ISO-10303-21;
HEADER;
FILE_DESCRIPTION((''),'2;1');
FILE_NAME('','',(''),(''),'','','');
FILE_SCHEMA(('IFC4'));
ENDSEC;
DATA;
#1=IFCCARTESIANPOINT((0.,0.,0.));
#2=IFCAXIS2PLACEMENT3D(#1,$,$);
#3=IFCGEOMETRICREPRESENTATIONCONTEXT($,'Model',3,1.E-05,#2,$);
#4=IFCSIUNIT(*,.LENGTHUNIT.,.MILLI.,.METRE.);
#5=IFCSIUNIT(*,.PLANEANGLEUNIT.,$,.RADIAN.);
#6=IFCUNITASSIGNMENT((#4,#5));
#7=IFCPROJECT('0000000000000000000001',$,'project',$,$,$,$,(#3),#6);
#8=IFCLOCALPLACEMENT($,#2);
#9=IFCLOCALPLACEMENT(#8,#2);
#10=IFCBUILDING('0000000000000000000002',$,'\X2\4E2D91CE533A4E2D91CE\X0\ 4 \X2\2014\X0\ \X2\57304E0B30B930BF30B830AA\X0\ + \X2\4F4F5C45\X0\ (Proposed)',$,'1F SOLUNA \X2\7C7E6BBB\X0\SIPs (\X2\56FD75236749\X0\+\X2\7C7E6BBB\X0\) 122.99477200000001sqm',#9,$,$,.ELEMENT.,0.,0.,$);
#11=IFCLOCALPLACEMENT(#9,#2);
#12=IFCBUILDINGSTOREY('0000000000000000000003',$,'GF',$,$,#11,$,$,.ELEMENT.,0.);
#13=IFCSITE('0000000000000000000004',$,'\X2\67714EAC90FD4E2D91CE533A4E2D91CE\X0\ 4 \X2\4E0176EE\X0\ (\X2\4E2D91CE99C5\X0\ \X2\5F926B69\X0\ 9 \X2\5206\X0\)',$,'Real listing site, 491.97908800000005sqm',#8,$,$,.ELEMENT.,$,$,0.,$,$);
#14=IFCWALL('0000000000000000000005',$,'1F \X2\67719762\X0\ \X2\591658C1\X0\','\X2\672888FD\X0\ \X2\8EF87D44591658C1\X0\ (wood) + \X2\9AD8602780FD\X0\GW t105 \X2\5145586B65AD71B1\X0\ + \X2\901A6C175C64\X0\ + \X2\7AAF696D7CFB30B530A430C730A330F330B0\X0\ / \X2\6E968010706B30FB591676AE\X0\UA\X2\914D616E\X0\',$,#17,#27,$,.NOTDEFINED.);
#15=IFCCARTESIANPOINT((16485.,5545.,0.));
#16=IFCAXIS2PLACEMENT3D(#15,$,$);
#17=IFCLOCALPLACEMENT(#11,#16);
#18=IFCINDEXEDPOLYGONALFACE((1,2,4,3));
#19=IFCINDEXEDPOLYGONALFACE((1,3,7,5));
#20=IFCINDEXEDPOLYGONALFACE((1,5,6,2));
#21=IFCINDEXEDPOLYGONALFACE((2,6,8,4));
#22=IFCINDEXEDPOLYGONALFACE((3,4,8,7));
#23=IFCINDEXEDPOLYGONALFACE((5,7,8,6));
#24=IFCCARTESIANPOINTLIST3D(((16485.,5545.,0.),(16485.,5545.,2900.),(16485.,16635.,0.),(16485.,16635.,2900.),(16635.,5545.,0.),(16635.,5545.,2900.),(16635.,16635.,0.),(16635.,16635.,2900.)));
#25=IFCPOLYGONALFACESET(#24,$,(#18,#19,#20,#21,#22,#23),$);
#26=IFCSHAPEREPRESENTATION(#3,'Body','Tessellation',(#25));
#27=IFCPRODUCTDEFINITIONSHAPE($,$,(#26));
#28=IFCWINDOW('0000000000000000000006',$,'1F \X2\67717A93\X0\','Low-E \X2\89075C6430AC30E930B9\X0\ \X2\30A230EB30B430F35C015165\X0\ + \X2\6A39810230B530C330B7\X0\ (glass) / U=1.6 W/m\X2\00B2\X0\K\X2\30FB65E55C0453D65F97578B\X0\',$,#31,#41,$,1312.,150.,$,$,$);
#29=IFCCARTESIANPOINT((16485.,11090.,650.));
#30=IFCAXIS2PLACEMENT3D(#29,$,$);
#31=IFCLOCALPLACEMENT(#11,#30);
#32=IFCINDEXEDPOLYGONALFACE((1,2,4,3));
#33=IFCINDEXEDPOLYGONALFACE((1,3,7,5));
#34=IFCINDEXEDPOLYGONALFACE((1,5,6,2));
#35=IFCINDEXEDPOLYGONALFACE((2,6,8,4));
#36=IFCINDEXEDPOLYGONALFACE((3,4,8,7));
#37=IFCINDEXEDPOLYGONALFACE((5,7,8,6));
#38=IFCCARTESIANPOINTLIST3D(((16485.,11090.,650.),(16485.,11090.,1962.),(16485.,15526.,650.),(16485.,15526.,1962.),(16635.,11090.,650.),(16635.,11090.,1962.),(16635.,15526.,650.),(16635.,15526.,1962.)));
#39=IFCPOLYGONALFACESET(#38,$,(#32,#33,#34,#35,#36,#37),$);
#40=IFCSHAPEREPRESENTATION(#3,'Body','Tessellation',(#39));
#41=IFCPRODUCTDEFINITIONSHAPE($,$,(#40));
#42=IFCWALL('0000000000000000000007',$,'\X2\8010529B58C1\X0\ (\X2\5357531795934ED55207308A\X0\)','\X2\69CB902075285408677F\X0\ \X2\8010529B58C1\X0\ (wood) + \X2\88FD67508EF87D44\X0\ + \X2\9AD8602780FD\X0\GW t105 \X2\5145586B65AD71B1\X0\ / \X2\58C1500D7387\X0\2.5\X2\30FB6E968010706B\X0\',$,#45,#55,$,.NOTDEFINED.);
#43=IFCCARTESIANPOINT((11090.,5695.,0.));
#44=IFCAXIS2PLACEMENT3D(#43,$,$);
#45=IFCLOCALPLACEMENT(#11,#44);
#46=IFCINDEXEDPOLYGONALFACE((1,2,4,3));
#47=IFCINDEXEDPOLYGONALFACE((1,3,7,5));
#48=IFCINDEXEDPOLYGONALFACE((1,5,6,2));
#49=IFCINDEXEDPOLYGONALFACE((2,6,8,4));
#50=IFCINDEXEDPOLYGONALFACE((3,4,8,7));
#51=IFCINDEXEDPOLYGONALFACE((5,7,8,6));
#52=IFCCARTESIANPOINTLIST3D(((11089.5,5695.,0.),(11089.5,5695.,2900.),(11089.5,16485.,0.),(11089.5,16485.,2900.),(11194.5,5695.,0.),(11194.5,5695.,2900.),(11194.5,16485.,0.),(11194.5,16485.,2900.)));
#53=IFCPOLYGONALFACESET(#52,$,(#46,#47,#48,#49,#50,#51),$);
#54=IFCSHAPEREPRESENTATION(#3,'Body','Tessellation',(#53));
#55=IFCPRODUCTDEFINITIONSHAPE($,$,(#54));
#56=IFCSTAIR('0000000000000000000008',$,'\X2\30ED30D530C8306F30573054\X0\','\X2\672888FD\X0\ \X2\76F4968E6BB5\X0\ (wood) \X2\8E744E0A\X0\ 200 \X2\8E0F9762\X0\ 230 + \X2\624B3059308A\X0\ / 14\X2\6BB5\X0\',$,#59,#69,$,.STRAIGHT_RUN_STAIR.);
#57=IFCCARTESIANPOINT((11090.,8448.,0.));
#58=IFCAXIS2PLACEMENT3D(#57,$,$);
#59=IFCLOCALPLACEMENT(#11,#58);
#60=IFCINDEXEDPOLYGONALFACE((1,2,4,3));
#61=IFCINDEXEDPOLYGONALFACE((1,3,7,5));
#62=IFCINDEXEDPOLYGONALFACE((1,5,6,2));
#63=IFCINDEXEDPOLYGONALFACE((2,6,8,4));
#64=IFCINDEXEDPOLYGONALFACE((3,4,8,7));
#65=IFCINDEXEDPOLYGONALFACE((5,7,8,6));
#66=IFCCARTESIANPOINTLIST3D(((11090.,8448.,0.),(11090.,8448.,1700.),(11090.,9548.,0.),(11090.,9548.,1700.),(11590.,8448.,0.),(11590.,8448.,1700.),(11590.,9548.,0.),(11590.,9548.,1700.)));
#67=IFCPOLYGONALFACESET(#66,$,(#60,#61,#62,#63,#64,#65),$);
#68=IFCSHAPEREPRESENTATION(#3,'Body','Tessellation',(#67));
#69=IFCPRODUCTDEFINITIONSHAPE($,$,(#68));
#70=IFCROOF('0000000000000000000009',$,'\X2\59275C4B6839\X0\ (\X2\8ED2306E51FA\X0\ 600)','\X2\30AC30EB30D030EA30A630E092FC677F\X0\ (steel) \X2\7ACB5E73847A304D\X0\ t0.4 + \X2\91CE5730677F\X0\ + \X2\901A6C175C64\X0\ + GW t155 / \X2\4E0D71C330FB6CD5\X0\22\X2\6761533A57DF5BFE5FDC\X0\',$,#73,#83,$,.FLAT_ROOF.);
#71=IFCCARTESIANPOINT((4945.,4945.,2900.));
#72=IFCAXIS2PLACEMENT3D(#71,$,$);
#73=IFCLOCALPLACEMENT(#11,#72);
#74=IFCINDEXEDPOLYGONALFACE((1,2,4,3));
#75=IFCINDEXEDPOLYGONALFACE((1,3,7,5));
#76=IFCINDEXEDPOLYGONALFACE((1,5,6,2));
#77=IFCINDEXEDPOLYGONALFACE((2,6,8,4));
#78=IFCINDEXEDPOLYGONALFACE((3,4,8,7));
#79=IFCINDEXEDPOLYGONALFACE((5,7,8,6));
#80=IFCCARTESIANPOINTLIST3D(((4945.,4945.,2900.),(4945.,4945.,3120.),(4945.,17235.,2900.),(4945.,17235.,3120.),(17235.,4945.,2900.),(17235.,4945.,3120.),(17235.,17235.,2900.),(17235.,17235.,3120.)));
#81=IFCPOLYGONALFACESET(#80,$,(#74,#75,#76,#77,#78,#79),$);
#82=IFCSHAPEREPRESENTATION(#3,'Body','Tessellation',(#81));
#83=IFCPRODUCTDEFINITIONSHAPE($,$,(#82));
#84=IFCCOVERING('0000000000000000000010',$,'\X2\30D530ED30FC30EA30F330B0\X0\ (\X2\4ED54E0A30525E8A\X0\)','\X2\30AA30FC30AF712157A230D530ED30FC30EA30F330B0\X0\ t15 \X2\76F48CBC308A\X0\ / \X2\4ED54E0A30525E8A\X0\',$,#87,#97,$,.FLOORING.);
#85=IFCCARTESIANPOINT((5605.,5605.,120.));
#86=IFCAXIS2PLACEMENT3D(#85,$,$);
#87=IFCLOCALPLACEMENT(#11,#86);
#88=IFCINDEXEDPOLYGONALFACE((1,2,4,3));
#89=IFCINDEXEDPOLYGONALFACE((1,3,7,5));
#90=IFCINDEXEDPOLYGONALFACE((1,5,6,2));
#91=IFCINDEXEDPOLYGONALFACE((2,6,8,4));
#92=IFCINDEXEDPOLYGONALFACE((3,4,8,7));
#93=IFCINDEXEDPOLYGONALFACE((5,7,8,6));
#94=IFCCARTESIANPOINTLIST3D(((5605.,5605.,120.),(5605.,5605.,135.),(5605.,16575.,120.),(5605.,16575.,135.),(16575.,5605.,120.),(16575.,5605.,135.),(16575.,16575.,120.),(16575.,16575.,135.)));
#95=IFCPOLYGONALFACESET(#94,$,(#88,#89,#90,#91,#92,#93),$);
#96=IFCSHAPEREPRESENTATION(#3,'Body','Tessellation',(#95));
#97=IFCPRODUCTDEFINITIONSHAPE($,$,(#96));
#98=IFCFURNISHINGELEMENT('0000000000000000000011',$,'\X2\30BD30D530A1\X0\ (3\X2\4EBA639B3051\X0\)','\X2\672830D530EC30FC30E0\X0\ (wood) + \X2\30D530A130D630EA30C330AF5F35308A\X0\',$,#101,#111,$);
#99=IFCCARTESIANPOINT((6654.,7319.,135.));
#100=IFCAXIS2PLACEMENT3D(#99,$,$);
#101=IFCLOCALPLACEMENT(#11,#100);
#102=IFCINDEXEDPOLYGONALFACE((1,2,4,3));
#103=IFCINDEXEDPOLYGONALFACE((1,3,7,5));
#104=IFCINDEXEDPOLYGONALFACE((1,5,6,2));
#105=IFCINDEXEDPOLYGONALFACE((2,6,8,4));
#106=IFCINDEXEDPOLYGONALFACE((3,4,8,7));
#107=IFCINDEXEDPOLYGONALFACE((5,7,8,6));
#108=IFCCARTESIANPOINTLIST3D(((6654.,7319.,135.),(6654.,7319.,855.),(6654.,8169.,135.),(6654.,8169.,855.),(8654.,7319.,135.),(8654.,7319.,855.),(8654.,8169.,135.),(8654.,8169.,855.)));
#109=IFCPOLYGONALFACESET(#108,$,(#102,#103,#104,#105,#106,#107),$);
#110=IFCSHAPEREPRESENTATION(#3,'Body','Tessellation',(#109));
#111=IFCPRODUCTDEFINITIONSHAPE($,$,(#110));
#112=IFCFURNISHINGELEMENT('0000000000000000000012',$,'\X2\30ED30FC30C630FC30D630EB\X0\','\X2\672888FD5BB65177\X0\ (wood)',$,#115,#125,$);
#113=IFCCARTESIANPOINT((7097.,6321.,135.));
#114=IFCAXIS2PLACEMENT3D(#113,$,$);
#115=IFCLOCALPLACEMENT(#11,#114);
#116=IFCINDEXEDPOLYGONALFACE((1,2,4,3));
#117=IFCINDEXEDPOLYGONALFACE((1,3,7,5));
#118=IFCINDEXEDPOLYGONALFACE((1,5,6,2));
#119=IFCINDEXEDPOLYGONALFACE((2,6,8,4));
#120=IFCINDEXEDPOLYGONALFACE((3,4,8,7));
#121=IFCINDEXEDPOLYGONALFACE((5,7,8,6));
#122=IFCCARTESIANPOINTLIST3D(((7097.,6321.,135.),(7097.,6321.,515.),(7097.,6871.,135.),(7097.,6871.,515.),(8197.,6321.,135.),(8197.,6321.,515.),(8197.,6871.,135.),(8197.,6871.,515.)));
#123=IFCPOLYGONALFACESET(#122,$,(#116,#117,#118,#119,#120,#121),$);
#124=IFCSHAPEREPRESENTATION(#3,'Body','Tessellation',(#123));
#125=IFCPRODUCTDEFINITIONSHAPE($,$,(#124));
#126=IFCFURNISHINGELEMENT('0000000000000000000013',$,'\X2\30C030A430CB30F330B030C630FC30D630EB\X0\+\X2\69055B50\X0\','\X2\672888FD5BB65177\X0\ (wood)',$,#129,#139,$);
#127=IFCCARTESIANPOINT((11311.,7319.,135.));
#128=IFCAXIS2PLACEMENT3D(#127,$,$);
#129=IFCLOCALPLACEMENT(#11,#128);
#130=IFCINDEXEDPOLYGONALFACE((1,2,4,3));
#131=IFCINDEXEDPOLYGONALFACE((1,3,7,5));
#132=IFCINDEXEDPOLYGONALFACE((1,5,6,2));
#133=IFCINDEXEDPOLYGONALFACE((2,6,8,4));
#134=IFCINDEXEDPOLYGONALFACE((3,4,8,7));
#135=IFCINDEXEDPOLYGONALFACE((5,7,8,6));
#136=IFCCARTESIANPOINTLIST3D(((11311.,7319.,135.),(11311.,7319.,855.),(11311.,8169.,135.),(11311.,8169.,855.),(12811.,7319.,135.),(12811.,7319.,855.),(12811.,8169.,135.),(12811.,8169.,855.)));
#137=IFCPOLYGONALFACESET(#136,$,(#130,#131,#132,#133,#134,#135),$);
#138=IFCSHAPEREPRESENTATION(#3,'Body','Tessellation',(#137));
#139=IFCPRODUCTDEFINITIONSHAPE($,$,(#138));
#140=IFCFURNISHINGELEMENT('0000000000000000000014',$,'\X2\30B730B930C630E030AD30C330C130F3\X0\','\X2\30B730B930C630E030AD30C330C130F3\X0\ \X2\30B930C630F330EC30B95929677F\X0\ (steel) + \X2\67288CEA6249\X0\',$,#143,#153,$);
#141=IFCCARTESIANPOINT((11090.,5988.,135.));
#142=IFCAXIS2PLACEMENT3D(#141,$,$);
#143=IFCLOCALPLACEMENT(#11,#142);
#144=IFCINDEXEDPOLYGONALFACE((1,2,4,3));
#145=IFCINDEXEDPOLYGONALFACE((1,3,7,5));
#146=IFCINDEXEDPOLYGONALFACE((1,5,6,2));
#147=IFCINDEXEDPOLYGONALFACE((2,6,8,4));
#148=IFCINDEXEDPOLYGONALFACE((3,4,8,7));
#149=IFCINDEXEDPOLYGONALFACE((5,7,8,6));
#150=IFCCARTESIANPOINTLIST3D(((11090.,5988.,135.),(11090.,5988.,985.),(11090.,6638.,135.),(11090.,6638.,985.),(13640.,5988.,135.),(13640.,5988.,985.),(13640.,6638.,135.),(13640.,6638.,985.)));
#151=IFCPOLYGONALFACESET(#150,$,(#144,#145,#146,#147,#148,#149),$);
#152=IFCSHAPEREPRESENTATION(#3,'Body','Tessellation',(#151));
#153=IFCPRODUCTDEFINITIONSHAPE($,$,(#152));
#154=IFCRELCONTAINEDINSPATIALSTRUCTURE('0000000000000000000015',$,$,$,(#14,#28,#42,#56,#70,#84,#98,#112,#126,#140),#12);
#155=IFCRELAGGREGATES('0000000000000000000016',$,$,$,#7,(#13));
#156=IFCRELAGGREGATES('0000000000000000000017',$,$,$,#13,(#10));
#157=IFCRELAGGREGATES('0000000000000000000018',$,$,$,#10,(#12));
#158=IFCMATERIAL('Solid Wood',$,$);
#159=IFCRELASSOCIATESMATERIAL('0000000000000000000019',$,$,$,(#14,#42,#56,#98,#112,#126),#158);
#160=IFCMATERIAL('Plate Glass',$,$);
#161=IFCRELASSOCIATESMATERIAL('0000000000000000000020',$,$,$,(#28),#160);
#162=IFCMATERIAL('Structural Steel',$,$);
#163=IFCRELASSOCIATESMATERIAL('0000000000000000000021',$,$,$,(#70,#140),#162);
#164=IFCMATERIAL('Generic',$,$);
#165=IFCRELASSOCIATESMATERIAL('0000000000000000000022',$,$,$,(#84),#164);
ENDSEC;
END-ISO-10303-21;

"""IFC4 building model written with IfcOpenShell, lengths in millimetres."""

from ifc_helpers import new_model, si_unit, frame, frame_2d, origin, place, context, project, spatial, rectangle, extrude, material, element, fill, save


model = new_model("IFC4")

# Units and contexts
model_context = context("Model", 3, precision=1e-05, world=origin())
ifc_project = project(units=[si_unit("LENGTHUNIT", "METRE", prefix="MILLI"), si_unit("PLANEANGLEUNIT", "RADIAN")], contexts=[model_context])

# Site, building, storey
site_placement = place(None, origin())
site = spatial("IfcSite", under=ifc_project, at=site_placement, Name="東京都中野区中野 4 丁目 (中野駅 徒歩 9 分)", ObjectType="Real listing site, 491.97908800000005sqm", CompositionType="ELEMENT", RefElevation=0.0)
building_placement = place(site_placement, origin())
building = spatial("IfcBuilding", under=site, at=building_placement, Name="中野区中野 4 — 地下スタジオ + 住居 (Proposed)", ObjectType="1F SOLUNA 籾殻SIPs (国産杉+籾殻) 122.99477200000001sqm", CompositionType="ELEMENT", ElevationOfRefHeight=0.0, ElevationOfTerrain=0.0)
storey_placement = place(building_placement, origin())
storey = spatial("IfcBuildingStorey", under=building, at=storey_placement, Name="GF", CompositionType="ELEMENT", Elevation=0.0)

# Shared definitions
ifc_material_1 = material(Name="Solid Wood")

# Shared definitions
ifc_material_2 = material(Name="Plate Glass")

# Wall, opening, window
wall_1_placement = place(storey_placement, frame((16485.0, 5545.0, 0.0)))
wall_1 = element("IfcWall", 1, at=wall_1_placement, inside=storey, material=ifc_material_1, Name="1F 東面 外壁", Description="木製 軸組外壁 (wood) + 高性能GW t105 充填断熱 + 通気層 + 窯業系サイディング / 準耐火・外皮UA配慮", PredefinedType="NOTDEFINED", context=model_context, shape_type="SweptSolid", body=[
    extrude(rectangle(XDim=150.0, YDim=11090.0, at=frame_2d((75.0, 5545.0))), frame((16485.0, 5545.0, 0.0)), (0.0, 0.0, 1.0), 2900.0),
])
opening_1_placement = place(storey_placement, frame((16485.0, 11090.0, 650.0)))
opening_1 = element("IfcOpeningElement", 2, at=opening_1_placement, cuts=wall_1, PredefinedType="NOTDEFINED", context=model_context, shape_type="SweptSolid", body=[
    extrude(rectangle(XDim=150.0, YDim=4436.0, at=frame_2d((75.0, 2218.0))), frame((16485.0, 11090.0, 650.0)), (0.0, 0.0, 1.0), 1312.0),
])
window_1_placement = place(storey_placement, frame((16485.0, 11090.0, 650.0)))
window_1 = element("IfcWindow", 3, at=window_1_placement, inside=storey, material=ifc_material_2, Name="1F 東窓", Description="Low-E 複層ガラス アルゴン封入 + 樹脂サッシ (glass) / U=1.6 W/m²K・日射取得型", OverallHeight=1312.0, OverallWidth=150.0, context=model_context, shape_type="SweptSolid", body=[
    extrude(rectangle(XDim=150.0, YDim=4436.0, at=frame_2d((75.0, 2218.0))), frame((16485.0, 11090.0, 650.0)), (0.0, 0.0, 1.0), 1312.0),
])
fill(opening_1, window_1)

# Wall
wall_2_placement = place(storey_placement, frame((11090.0, 5695.0, 0.0)))
element("IfcWall", 4, at=wall_2_placement, inside=storey, material=ifc_material_1, Name="耐力壁 (南北間仕切り)", Description="構造用合板 耐力壁 (wood) + 製材軸組 + 高性能GW t105 充填断熱 / 壁倍率2.5・準耐火", PredefinedType="NOTDEFINED", context=model_context, shape_type="SweptSolid", body=[
    extrude(rectangle(XDim=105.0, YDim=10790.0, at=frame_2d((52.0, 5395.0))), frame((11090.0, 5695.0, 0.0)), (0.0, 0.0, 1.0), 2900.0),
])

# Stair
stair_placement = place(storey_placement, frame((11090.0, 8448.0, 0.0)))
element("IfcStair", 5, at=stair_placement, inside=storey, material=ifc_material_1, Name="ロフトはしご", Description="木製 直階段 (wood) 蹴上 200 踏面 230 + 手すり / 14段", PredefinedType="STRAIGHT_RUN_STAIR", context=model_context, shape_type="SweptSolid", body=[
    extrude(rectangle(XDim=500.0, YDim=1100.0, at=frame_2d((250.0, 550.0))), frame((11090.0, 8448.0, 0.0)), (0.0, 0.0, 1.0), 1700.0),
])

# Roof
ifc_material_3 = material(Name="Structural Steel")
roof_placement = place(storey_placement, frame((4945.0, 4945.0, 2900.0)))
element("IfcRoof", 6, at=roof_placement, inside=storey, material=ifc_material_3, Name="大屋根 (軒の出 600)", Description="ガルバリウム鋼板 (steel) 立平葺き t0.4 + 野地板 + 通気層 + GW t155 / 不燃・法22条区域対応", PredefinedType="FLAT_ROOF", context=model_context, shape_type="SweptSolid", body=[
    extrude(rectangle(XDim=12290.0, YDim=12290.0, at=frame_2d((6145.0, 6145.0))), frame((4945.0, 4945.0, 2900.0)), (0.0, 0.0, 1.0), 220.0),
])

# Covering
ifc_material_4 = material(Name="Generic")
covering_placement = place(storey_placement, frame((5605.0, 5605.0, 120.0)))
element("IfcCovering", 7, at=covering_placement, inside=storey, material=ifc_material_4, Name="フローリング (仕上げ床)", Description="オーク無垢フローリング t15 直貼り / 仕上げ床", PredefinedType="FLOORING", context=model_context, shape_type="SweptSolid", body=[
    extrude(rectangle(XDim=10970.0, YDim=10970.0, at=frame_2d((5485.0, 5485.0))), frame((5605.0, 5605.0, 120.0)), (0.0, 0.0, 1.0), 15.0),
])

# Furnishing elements
furnishing_1_placement = place(storey_placement, frame((6654.0, 7319.0, 135.0)))
element("IfcFurnishingElement", 8, at=furnishing_1_placement, inside=storey, material=ifc_material_1, Name="ソファ (3人掛け)", Description="木フレーム (wood) + ファブリック張り", context=model_context, shape_type="SweptSolid", body=[
    extrude(rectangle(XDim=2000.0, YDim=850.0, at=frame_2d((1000.0, 425.0))), frame((6654.0, 7319.0, 135.0)), (0.0, 0.0, 1.0), 720.0),
])
furnishing_2_placement = place(storey_placement, frame((7097.0, 6321.0, 135.0)))
element("IfcFurnishingElement", 9, at=furnishing_2_placement, inside=storey, material=ifc_material_1, Name="ローテーブル", Description="木製家具 (wood)", context=model_context, shape_type="SweptSolid", body=[
    extrude(rectangle(XDim=1100.0, YDim=550.0, at=frame_2d((550.0, 275.0))), frame((7097.0, 6321.0, 135.0)), (0.0, 0.0, 1.0), 380.0),
])
furnishing_3_placement = place(storey_placement, frame((11311.0, 7319.0, 135.0)))
element("IfcFurnishingElement", 10, at=furnishing_3_placement, inside=storey, material=ifc_material_1, Name="ダイニングテーブル+椅子", Description="木製家具 (wood)", context=model_context, shape_type="SweptSolid", body=[
    extrude(rectangle(XDim=1500.0, YDim=850.0, at=frame_2d((750.0, 425.0))), frame((11311.0, 7319.0, 135.0)), (0.0, 0.0, 1.0), 720.0),
])
furnishing_4_placement = place(storey_placement, frame((11090.0, 5988.0, 135.0)))
element("IfcFurnishingElement", 11, at=furnishing_4_placement, inside=storey, material=ifc_material_3, Name="システムキッチン", Description="システムキッチン ステンレス天板 (steel) + 木質扉", context=model_context, shape_type="SweptSolid", body=[
    extrude(rectangle(XDim=2550.0, YDim=650.0, at=frame_2d((1275.0, 325.0))), frame((11090.0, 5988.0, 135.0)), (0.0, 0.0, 1.0), 850.0),
])

save(model, "model.ifc")
